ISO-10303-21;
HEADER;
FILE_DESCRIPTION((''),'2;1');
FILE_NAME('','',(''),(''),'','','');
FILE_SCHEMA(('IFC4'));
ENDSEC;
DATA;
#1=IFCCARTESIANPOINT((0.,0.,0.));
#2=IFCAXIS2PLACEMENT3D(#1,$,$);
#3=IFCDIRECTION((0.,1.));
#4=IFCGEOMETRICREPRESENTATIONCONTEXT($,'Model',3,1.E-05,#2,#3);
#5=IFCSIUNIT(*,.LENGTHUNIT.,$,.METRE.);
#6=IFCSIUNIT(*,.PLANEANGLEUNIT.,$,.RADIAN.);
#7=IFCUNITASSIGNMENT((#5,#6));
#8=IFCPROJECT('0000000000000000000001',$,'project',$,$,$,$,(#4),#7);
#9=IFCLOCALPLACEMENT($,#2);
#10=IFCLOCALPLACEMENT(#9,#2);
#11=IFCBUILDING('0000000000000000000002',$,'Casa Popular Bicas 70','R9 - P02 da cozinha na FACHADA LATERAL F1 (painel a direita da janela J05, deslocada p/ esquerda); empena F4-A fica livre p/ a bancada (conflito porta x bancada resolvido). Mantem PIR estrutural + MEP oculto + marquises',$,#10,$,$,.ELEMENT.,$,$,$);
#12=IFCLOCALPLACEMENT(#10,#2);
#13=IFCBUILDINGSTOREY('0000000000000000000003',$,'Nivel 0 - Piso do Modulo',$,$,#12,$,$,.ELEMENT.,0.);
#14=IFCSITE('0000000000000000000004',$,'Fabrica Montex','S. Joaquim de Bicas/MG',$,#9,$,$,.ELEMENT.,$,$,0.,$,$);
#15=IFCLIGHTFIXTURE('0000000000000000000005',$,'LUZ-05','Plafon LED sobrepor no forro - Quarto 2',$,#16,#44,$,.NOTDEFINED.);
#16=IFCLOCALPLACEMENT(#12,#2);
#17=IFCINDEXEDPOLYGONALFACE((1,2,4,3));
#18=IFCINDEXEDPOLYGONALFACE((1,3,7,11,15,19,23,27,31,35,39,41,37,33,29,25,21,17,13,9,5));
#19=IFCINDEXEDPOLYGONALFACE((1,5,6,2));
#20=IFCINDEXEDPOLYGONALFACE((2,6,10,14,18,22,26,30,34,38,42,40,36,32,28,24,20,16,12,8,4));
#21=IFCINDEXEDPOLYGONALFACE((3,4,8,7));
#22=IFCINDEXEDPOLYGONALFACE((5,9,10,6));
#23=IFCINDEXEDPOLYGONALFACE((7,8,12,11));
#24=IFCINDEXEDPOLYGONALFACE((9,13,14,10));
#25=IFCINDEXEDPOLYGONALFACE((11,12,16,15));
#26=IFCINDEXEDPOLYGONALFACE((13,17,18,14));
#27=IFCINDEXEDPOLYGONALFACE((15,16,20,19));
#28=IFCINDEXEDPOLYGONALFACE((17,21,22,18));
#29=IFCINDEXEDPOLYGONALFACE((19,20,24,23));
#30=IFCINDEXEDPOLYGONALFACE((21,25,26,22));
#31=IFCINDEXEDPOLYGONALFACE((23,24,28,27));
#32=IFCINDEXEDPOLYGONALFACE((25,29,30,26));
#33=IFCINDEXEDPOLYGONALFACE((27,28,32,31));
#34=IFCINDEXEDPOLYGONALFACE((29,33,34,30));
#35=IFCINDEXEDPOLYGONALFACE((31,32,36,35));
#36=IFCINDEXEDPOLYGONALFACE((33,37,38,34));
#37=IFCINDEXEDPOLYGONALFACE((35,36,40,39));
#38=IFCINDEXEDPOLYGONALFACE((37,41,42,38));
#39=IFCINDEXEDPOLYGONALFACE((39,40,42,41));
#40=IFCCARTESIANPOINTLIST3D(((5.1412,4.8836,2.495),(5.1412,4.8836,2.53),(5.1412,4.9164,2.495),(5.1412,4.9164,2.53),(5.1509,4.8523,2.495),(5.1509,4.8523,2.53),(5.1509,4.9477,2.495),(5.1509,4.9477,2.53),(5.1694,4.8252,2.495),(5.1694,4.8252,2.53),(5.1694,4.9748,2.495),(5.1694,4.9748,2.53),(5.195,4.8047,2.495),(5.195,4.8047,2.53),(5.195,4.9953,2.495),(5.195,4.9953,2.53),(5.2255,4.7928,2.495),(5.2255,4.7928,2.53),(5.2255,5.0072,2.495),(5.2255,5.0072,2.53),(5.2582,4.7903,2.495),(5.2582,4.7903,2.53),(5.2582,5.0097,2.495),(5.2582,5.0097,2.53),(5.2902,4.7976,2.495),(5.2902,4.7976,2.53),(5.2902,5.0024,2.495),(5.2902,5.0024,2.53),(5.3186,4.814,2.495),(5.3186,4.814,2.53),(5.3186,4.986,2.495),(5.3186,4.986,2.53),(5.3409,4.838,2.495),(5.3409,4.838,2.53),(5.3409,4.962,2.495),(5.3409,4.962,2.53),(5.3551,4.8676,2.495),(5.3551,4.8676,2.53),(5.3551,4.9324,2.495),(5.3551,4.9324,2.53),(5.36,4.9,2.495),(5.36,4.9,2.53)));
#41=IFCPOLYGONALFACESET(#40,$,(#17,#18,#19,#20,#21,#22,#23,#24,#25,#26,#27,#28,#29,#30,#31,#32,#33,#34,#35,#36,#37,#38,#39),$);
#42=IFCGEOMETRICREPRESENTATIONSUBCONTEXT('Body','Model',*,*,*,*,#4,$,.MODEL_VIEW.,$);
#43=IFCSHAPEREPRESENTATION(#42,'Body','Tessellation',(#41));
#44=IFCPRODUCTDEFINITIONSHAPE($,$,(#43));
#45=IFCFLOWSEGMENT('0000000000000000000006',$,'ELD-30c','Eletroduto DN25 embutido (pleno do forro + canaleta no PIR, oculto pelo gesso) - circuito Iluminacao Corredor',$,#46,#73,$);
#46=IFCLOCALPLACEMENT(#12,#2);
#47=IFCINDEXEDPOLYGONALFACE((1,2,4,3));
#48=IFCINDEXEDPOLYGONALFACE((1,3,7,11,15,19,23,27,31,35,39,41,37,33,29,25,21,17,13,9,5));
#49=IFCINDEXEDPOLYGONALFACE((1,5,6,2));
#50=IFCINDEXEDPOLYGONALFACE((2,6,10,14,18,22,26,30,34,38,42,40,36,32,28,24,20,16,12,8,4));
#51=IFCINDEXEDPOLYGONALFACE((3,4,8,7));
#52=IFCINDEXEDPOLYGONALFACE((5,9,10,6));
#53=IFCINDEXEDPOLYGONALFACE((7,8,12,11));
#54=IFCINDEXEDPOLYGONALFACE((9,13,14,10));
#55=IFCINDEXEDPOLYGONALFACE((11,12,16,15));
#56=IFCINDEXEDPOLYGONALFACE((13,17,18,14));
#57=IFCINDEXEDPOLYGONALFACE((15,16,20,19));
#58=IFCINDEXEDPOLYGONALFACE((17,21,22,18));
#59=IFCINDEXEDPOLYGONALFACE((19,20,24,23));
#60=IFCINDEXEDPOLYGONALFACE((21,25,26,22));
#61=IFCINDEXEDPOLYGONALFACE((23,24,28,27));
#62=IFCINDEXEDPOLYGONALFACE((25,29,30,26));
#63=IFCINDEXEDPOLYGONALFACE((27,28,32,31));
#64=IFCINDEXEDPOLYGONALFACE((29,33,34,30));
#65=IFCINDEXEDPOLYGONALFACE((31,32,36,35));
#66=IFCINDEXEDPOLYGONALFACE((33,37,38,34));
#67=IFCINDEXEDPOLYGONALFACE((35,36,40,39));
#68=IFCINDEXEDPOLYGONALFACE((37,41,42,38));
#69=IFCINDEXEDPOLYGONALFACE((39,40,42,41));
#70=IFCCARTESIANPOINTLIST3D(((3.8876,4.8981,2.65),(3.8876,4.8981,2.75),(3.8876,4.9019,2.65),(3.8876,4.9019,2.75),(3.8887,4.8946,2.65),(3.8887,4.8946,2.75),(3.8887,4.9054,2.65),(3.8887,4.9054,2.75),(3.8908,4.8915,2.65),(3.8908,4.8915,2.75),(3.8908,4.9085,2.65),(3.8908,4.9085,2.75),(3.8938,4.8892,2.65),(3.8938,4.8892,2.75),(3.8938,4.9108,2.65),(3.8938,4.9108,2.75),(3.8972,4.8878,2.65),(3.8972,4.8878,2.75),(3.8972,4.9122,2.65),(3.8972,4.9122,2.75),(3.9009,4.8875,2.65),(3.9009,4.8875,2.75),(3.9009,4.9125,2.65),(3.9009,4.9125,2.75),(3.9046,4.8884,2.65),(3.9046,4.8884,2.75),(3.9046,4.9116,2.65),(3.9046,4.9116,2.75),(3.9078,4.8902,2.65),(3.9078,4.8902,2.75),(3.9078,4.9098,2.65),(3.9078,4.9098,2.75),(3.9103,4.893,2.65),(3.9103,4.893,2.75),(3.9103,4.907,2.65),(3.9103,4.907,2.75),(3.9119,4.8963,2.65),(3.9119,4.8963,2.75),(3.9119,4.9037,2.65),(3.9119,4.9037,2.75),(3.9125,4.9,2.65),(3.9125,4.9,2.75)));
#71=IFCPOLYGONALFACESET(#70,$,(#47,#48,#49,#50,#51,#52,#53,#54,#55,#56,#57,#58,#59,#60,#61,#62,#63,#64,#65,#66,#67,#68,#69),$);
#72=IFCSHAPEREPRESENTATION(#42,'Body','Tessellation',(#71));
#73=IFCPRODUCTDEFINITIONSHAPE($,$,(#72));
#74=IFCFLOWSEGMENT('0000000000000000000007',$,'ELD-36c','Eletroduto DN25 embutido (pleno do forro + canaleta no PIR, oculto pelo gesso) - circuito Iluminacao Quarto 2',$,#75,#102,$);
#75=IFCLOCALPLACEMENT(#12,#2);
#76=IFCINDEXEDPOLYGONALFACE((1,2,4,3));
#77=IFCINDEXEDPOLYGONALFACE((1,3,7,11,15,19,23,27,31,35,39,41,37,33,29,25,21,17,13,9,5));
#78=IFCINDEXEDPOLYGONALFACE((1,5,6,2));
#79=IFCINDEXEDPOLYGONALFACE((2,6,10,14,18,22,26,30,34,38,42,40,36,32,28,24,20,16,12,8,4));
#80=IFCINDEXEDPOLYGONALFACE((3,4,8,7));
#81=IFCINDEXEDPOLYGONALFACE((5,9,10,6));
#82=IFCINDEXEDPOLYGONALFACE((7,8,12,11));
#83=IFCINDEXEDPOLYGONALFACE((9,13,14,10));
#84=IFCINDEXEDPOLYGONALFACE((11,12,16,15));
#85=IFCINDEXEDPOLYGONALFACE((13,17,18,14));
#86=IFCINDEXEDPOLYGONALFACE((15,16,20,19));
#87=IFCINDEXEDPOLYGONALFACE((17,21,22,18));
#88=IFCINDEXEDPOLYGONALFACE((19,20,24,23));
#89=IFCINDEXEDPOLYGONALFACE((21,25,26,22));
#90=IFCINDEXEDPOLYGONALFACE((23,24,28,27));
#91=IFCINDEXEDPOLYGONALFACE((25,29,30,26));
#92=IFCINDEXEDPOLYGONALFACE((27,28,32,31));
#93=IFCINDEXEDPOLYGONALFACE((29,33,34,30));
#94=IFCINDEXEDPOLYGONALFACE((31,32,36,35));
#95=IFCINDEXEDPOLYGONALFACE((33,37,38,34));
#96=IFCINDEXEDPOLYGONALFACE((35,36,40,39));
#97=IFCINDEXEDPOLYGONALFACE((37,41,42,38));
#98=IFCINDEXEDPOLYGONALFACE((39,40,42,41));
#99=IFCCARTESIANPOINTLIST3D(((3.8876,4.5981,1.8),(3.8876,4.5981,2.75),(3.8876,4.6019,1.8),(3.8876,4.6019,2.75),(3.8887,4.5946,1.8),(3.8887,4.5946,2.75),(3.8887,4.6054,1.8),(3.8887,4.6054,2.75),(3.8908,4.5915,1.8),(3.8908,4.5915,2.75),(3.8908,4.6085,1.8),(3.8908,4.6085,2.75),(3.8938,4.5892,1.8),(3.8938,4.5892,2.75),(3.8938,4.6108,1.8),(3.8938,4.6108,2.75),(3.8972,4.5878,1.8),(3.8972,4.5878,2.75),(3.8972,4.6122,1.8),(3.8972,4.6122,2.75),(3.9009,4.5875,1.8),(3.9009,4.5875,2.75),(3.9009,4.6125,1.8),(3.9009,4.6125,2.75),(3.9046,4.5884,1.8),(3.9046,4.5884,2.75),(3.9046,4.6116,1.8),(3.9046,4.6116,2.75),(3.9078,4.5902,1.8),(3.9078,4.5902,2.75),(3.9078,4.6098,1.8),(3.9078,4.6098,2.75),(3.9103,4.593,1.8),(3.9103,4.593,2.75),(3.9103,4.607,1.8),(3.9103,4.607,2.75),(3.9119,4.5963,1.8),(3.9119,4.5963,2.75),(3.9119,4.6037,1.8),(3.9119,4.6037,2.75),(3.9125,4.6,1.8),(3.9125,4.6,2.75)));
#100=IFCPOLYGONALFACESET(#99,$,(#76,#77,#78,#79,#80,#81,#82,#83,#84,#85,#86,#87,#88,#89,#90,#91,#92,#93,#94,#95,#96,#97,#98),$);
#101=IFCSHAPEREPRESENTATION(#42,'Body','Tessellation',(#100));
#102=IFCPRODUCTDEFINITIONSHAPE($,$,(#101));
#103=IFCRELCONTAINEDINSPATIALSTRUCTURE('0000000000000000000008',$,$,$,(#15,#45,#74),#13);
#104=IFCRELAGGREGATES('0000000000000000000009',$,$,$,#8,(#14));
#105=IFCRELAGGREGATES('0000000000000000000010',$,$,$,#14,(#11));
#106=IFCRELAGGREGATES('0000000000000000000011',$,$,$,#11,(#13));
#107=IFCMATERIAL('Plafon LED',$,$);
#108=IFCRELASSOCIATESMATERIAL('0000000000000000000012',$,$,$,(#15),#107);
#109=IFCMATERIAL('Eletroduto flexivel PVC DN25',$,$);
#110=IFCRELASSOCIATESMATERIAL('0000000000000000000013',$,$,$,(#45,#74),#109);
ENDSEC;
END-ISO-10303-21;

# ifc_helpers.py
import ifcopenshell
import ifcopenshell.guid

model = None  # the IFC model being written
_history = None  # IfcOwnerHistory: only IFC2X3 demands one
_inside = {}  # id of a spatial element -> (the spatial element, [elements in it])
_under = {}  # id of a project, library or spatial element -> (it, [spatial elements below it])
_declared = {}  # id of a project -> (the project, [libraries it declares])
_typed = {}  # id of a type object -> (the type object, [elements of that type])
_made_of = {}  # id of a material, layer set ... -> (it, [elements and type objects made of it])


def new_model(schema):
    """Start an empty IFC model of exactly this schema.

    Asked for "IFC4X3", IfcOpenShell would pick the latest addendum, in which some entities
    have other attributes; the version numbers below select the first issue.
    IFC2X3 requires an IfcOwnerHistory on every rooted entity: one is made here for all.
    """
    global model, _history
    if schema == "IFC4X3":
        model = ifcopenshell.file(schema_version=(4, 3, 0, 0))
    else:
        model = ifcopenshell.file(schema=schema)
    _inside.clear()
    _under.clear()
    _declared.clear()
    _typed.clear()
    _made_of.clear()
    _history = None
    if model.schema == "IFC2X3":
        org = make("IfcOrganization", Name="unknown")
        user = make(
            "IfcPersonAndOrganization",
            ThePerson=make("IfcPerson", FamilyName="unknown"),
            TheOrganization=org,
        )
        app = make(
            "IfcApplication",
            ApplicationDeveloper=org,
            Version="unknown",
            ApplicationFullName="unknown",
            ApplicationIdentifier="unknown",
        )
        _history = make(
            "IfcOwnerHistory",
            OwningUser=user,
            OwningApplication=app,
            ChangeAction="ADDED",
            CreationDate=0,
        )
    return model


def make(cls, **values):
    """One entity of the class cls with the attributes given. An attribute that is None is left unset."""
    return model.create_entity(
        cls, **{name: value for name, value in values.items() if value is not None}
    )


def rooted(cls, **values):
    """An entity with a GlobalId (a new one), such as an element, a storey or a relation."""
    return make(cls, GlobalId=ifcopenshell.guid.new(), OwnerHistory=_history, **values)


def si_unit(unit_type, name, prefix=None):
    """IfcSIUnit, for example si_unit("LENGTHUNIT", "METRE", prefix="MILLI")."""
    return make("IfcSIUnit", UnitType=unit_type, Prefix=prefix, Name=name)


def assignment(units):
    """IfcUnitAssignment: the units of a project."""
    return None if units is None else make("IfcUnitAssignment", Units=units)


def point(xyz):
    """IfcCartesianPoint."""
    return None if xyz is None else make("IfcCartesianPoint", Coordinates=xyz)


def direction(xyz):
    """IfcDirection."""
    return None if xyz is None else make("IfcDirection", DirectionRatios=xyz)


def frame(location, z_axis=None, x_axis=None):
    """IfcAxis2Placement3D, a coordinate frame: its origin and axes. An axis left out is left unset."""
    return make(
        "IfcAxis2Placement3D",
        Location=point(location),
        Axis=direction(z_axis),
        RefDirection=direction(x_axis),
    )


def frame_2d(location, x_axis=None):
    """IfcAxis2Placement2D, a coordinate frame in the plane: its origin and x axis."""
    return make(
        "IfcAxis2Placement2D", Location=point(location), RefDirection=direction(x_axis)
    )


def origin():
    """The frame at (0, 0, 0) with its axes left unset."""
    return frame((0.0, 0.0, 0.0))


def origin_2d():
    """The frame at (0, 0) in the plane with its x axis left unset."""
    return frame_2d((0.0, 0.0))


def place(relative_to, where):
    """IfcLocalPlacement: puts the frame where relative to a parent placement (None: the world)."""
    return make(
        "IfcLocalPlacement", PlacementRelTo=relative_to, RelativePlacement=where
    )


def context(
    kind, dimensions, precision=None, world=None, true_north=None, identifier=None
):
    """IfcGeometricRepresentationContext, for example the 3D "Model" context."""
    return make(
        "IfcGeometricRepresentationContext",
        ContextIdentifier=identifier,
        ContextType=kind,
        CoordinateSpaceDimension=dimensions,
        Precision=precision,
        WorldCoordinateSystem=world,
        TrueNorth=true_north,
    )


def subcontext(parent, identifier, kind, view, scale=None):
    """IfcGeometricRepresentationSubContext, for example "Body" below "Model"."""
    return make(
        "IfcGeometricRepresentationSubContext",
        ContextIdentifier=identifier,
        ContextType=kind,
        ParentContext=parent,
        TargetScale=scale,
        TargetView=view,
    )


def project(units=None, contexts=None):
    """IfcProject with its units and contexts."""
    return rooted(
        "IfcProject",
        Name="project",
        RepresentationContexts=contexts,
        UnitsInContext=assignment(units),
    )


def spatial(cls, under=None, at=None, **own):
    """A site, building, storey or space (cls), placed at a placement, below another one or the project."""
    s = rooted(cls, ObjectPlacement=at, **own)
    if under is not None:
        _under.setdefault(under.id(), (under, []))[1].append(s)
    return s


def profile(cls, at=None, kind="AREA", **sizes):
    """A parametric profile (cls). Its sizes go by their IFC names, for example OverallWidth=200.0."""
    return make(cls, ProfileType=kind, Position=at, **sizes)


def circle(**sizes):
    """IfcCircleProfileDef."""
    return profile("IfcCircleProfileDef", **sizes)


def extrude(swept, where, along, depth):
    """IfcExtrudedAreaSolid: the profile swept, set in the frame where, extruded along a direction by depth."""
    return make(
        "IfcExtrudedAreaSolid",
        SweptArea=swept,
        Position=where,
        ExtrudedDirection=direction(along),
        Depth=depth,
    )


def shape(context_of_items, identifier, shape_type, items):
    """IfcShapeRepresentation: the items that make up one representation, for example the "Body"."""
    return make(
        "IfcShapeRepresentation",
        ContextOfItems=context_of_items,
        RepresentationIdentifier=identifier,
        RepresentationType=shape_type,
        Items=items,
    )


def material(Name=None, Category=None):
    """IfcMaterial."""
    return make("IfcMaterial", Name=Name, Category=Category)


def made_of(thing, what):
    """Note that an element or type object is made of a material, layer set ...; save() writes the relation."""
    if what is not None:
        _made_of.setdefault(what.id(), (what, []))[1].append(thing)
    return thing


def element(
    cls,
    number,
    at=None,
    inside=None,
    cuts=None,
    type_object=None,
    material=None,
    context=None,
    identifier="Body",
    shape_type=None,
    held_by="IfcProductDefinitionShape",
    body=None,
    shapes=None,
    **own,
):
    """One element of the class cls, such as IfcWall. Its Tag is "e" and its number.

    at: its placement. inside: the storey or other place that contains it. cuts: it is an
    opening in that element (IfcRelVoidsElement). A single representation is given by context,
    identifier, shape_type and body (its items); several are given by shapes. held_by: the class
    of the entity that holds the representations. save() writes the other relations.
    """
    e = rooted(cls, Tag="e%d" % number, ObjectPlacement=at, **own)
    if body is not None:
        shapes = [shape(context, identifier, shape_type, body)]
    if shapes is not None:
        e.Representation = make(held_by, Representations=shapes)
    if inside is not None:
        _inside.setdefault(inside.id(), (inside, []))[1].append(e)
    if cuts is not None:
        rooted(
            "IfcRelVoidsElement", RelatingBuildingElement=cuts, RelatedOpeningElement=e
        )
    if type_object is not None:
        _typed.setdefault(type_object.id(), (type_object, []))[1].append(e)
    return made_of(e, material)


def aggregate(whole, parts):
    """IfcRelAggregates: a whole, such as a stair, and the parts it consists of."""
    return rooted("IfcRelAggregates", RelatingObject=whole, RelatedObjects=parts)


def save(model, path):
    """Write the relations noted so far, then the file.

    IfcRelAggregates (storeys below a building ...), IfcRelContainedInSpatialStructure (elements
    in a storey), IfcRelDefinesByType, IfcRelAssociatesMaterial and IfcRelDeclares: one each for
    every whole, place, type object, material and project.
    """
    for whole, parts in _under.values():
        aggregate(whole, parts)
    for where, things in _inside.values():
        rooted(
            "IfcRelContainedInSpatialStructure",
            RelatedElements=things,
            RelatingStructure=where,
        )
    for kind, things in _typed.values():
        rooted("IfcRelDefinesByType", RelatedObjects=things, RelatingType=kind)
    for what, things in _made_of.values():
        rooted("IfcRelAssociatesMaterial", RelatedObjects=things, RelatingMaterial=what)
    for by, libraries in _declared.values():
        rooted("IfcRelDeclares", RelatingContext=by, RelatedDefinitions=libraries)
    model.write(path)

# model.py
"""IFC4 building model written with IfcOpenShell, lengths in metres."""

from ifc_helpers import new_model, si_unit, direction, frame, origin, origin_2d, place, context, subcontext, project, spatial, circle, extrude, material, element, save


model = new_model("IFC4")

# Units and contexts
model_context = context("Model", 3, precision=1e-05, world=origin(), true_north=direction((0.0, 1.0)))
body_context = subcontext(model_context, "Body", "Model", "MODEL_VIEW")
ifc_project = project(units=[si_unit("LENGTHUNIT", "METRE"), si_unit("PLANEANGLEUNIT", "RADIAN")], contexts=[model_context])

# Site, building, storey
site_placement = place(None, origin())
site = spatial("IfcSite", under=ifc_project, at=site_placement, Name="Fabrica Montex", Description="S. Joaquim de Bicas/MG", CompositionType="ELEMENT", RefElevation=0.0)
building_placement = place(site_placement, origin())
building = spatial("IfcBuilding", under=site, at=building_placement, Name="Casa Popular Bicas 70", Description="R9 - P02 da cozinha na FACHADA LATERAL F1 (painel a direita da janela J05, deslocada p/ esquerda); empena F4-A fica livre p/ a bancada (conflito porta x bancada resolvido). Mantem PIR estrutural + MEP oculto + marquises", CompositionType="ELEMENT")
storey_placement = place(building_placement, origin())
storey = spatial("IfcBuildingStorey", under=building, at=storey_placement, Name="Nivel 0 - Piso do Modulo", CompositionType="ELEMENT", Elevation=0.0)

# Shared definitions
ifc_material_1 = material(Name="Eletroduto flexivel PVC DN25")

# Light fixture
ifc_material_2 = material(Name="Plafon LED")
light_fixture_placement = place(storey_placement, frame((5.25, 4.9, 2.495)))
element("IfcLightFixture", 1, at=light_fixture_placement, inside=storey, material=ifc_material_2, Name="LUZ-05", Description="Plafon LED sobrepor no forro - Quarto 2", PredefinedType="NOTDEFINED", context=body_context, shape_type="SweptSolid", body=[
    extrude(circle(Radius=0.11, at=origin_2d()), origin(), (0.0, 0.0, 1.0), 0.035),
])

# Flow segments
flow_segment_1_placement = place(storey_placement, frame((3.9, 4.9, 2.75), z_axis=(0.0, 0.0, -1.0), x_axis=(1.0, 0.0, 0.0)))
element("IfcFlowSegment", 2, at=flow_segment_1_placement, inside=storey, material=ifc_material_1, Name="ELD-30c", Description="Eletroduto DN25 embutido (pleno do forro + canaleta no PIR, oculto pelo gesso) - circuito Iluminacao Corredor", context=body_context, shape_type="SweptSolid", body=[
    extrude(circle(Radius=0.0125, at=origin_2d()), origin(), (0.0, 0.0, 1.0), 0.1),
])
flow_segment_2_placement = place(storey_placement, frame((3.9, 4.6, 2.75), z_axis=(0.0, 0.0, -1.0), x_axis=(1.0, 0.0, 0.0)))
element("IfcFlowSegment", 3, at=flow_segment_2_placement, inside=storey, material=ifc_material_1, Name="ELD-36c", Description="Eletroduto DN25 embutido (pleno do forro + canaleta no PIR, oculto pelo gesso) - circuito Iluminacao Quarto 2", context=body_context, shape_type="SweptSolid", body=[
    extrude(circle(Radius=0.0125, at=origin_2d()), origin(), (0.0, 0.0, 1.0), 0.95),
])

save(model, "model.ifc")
